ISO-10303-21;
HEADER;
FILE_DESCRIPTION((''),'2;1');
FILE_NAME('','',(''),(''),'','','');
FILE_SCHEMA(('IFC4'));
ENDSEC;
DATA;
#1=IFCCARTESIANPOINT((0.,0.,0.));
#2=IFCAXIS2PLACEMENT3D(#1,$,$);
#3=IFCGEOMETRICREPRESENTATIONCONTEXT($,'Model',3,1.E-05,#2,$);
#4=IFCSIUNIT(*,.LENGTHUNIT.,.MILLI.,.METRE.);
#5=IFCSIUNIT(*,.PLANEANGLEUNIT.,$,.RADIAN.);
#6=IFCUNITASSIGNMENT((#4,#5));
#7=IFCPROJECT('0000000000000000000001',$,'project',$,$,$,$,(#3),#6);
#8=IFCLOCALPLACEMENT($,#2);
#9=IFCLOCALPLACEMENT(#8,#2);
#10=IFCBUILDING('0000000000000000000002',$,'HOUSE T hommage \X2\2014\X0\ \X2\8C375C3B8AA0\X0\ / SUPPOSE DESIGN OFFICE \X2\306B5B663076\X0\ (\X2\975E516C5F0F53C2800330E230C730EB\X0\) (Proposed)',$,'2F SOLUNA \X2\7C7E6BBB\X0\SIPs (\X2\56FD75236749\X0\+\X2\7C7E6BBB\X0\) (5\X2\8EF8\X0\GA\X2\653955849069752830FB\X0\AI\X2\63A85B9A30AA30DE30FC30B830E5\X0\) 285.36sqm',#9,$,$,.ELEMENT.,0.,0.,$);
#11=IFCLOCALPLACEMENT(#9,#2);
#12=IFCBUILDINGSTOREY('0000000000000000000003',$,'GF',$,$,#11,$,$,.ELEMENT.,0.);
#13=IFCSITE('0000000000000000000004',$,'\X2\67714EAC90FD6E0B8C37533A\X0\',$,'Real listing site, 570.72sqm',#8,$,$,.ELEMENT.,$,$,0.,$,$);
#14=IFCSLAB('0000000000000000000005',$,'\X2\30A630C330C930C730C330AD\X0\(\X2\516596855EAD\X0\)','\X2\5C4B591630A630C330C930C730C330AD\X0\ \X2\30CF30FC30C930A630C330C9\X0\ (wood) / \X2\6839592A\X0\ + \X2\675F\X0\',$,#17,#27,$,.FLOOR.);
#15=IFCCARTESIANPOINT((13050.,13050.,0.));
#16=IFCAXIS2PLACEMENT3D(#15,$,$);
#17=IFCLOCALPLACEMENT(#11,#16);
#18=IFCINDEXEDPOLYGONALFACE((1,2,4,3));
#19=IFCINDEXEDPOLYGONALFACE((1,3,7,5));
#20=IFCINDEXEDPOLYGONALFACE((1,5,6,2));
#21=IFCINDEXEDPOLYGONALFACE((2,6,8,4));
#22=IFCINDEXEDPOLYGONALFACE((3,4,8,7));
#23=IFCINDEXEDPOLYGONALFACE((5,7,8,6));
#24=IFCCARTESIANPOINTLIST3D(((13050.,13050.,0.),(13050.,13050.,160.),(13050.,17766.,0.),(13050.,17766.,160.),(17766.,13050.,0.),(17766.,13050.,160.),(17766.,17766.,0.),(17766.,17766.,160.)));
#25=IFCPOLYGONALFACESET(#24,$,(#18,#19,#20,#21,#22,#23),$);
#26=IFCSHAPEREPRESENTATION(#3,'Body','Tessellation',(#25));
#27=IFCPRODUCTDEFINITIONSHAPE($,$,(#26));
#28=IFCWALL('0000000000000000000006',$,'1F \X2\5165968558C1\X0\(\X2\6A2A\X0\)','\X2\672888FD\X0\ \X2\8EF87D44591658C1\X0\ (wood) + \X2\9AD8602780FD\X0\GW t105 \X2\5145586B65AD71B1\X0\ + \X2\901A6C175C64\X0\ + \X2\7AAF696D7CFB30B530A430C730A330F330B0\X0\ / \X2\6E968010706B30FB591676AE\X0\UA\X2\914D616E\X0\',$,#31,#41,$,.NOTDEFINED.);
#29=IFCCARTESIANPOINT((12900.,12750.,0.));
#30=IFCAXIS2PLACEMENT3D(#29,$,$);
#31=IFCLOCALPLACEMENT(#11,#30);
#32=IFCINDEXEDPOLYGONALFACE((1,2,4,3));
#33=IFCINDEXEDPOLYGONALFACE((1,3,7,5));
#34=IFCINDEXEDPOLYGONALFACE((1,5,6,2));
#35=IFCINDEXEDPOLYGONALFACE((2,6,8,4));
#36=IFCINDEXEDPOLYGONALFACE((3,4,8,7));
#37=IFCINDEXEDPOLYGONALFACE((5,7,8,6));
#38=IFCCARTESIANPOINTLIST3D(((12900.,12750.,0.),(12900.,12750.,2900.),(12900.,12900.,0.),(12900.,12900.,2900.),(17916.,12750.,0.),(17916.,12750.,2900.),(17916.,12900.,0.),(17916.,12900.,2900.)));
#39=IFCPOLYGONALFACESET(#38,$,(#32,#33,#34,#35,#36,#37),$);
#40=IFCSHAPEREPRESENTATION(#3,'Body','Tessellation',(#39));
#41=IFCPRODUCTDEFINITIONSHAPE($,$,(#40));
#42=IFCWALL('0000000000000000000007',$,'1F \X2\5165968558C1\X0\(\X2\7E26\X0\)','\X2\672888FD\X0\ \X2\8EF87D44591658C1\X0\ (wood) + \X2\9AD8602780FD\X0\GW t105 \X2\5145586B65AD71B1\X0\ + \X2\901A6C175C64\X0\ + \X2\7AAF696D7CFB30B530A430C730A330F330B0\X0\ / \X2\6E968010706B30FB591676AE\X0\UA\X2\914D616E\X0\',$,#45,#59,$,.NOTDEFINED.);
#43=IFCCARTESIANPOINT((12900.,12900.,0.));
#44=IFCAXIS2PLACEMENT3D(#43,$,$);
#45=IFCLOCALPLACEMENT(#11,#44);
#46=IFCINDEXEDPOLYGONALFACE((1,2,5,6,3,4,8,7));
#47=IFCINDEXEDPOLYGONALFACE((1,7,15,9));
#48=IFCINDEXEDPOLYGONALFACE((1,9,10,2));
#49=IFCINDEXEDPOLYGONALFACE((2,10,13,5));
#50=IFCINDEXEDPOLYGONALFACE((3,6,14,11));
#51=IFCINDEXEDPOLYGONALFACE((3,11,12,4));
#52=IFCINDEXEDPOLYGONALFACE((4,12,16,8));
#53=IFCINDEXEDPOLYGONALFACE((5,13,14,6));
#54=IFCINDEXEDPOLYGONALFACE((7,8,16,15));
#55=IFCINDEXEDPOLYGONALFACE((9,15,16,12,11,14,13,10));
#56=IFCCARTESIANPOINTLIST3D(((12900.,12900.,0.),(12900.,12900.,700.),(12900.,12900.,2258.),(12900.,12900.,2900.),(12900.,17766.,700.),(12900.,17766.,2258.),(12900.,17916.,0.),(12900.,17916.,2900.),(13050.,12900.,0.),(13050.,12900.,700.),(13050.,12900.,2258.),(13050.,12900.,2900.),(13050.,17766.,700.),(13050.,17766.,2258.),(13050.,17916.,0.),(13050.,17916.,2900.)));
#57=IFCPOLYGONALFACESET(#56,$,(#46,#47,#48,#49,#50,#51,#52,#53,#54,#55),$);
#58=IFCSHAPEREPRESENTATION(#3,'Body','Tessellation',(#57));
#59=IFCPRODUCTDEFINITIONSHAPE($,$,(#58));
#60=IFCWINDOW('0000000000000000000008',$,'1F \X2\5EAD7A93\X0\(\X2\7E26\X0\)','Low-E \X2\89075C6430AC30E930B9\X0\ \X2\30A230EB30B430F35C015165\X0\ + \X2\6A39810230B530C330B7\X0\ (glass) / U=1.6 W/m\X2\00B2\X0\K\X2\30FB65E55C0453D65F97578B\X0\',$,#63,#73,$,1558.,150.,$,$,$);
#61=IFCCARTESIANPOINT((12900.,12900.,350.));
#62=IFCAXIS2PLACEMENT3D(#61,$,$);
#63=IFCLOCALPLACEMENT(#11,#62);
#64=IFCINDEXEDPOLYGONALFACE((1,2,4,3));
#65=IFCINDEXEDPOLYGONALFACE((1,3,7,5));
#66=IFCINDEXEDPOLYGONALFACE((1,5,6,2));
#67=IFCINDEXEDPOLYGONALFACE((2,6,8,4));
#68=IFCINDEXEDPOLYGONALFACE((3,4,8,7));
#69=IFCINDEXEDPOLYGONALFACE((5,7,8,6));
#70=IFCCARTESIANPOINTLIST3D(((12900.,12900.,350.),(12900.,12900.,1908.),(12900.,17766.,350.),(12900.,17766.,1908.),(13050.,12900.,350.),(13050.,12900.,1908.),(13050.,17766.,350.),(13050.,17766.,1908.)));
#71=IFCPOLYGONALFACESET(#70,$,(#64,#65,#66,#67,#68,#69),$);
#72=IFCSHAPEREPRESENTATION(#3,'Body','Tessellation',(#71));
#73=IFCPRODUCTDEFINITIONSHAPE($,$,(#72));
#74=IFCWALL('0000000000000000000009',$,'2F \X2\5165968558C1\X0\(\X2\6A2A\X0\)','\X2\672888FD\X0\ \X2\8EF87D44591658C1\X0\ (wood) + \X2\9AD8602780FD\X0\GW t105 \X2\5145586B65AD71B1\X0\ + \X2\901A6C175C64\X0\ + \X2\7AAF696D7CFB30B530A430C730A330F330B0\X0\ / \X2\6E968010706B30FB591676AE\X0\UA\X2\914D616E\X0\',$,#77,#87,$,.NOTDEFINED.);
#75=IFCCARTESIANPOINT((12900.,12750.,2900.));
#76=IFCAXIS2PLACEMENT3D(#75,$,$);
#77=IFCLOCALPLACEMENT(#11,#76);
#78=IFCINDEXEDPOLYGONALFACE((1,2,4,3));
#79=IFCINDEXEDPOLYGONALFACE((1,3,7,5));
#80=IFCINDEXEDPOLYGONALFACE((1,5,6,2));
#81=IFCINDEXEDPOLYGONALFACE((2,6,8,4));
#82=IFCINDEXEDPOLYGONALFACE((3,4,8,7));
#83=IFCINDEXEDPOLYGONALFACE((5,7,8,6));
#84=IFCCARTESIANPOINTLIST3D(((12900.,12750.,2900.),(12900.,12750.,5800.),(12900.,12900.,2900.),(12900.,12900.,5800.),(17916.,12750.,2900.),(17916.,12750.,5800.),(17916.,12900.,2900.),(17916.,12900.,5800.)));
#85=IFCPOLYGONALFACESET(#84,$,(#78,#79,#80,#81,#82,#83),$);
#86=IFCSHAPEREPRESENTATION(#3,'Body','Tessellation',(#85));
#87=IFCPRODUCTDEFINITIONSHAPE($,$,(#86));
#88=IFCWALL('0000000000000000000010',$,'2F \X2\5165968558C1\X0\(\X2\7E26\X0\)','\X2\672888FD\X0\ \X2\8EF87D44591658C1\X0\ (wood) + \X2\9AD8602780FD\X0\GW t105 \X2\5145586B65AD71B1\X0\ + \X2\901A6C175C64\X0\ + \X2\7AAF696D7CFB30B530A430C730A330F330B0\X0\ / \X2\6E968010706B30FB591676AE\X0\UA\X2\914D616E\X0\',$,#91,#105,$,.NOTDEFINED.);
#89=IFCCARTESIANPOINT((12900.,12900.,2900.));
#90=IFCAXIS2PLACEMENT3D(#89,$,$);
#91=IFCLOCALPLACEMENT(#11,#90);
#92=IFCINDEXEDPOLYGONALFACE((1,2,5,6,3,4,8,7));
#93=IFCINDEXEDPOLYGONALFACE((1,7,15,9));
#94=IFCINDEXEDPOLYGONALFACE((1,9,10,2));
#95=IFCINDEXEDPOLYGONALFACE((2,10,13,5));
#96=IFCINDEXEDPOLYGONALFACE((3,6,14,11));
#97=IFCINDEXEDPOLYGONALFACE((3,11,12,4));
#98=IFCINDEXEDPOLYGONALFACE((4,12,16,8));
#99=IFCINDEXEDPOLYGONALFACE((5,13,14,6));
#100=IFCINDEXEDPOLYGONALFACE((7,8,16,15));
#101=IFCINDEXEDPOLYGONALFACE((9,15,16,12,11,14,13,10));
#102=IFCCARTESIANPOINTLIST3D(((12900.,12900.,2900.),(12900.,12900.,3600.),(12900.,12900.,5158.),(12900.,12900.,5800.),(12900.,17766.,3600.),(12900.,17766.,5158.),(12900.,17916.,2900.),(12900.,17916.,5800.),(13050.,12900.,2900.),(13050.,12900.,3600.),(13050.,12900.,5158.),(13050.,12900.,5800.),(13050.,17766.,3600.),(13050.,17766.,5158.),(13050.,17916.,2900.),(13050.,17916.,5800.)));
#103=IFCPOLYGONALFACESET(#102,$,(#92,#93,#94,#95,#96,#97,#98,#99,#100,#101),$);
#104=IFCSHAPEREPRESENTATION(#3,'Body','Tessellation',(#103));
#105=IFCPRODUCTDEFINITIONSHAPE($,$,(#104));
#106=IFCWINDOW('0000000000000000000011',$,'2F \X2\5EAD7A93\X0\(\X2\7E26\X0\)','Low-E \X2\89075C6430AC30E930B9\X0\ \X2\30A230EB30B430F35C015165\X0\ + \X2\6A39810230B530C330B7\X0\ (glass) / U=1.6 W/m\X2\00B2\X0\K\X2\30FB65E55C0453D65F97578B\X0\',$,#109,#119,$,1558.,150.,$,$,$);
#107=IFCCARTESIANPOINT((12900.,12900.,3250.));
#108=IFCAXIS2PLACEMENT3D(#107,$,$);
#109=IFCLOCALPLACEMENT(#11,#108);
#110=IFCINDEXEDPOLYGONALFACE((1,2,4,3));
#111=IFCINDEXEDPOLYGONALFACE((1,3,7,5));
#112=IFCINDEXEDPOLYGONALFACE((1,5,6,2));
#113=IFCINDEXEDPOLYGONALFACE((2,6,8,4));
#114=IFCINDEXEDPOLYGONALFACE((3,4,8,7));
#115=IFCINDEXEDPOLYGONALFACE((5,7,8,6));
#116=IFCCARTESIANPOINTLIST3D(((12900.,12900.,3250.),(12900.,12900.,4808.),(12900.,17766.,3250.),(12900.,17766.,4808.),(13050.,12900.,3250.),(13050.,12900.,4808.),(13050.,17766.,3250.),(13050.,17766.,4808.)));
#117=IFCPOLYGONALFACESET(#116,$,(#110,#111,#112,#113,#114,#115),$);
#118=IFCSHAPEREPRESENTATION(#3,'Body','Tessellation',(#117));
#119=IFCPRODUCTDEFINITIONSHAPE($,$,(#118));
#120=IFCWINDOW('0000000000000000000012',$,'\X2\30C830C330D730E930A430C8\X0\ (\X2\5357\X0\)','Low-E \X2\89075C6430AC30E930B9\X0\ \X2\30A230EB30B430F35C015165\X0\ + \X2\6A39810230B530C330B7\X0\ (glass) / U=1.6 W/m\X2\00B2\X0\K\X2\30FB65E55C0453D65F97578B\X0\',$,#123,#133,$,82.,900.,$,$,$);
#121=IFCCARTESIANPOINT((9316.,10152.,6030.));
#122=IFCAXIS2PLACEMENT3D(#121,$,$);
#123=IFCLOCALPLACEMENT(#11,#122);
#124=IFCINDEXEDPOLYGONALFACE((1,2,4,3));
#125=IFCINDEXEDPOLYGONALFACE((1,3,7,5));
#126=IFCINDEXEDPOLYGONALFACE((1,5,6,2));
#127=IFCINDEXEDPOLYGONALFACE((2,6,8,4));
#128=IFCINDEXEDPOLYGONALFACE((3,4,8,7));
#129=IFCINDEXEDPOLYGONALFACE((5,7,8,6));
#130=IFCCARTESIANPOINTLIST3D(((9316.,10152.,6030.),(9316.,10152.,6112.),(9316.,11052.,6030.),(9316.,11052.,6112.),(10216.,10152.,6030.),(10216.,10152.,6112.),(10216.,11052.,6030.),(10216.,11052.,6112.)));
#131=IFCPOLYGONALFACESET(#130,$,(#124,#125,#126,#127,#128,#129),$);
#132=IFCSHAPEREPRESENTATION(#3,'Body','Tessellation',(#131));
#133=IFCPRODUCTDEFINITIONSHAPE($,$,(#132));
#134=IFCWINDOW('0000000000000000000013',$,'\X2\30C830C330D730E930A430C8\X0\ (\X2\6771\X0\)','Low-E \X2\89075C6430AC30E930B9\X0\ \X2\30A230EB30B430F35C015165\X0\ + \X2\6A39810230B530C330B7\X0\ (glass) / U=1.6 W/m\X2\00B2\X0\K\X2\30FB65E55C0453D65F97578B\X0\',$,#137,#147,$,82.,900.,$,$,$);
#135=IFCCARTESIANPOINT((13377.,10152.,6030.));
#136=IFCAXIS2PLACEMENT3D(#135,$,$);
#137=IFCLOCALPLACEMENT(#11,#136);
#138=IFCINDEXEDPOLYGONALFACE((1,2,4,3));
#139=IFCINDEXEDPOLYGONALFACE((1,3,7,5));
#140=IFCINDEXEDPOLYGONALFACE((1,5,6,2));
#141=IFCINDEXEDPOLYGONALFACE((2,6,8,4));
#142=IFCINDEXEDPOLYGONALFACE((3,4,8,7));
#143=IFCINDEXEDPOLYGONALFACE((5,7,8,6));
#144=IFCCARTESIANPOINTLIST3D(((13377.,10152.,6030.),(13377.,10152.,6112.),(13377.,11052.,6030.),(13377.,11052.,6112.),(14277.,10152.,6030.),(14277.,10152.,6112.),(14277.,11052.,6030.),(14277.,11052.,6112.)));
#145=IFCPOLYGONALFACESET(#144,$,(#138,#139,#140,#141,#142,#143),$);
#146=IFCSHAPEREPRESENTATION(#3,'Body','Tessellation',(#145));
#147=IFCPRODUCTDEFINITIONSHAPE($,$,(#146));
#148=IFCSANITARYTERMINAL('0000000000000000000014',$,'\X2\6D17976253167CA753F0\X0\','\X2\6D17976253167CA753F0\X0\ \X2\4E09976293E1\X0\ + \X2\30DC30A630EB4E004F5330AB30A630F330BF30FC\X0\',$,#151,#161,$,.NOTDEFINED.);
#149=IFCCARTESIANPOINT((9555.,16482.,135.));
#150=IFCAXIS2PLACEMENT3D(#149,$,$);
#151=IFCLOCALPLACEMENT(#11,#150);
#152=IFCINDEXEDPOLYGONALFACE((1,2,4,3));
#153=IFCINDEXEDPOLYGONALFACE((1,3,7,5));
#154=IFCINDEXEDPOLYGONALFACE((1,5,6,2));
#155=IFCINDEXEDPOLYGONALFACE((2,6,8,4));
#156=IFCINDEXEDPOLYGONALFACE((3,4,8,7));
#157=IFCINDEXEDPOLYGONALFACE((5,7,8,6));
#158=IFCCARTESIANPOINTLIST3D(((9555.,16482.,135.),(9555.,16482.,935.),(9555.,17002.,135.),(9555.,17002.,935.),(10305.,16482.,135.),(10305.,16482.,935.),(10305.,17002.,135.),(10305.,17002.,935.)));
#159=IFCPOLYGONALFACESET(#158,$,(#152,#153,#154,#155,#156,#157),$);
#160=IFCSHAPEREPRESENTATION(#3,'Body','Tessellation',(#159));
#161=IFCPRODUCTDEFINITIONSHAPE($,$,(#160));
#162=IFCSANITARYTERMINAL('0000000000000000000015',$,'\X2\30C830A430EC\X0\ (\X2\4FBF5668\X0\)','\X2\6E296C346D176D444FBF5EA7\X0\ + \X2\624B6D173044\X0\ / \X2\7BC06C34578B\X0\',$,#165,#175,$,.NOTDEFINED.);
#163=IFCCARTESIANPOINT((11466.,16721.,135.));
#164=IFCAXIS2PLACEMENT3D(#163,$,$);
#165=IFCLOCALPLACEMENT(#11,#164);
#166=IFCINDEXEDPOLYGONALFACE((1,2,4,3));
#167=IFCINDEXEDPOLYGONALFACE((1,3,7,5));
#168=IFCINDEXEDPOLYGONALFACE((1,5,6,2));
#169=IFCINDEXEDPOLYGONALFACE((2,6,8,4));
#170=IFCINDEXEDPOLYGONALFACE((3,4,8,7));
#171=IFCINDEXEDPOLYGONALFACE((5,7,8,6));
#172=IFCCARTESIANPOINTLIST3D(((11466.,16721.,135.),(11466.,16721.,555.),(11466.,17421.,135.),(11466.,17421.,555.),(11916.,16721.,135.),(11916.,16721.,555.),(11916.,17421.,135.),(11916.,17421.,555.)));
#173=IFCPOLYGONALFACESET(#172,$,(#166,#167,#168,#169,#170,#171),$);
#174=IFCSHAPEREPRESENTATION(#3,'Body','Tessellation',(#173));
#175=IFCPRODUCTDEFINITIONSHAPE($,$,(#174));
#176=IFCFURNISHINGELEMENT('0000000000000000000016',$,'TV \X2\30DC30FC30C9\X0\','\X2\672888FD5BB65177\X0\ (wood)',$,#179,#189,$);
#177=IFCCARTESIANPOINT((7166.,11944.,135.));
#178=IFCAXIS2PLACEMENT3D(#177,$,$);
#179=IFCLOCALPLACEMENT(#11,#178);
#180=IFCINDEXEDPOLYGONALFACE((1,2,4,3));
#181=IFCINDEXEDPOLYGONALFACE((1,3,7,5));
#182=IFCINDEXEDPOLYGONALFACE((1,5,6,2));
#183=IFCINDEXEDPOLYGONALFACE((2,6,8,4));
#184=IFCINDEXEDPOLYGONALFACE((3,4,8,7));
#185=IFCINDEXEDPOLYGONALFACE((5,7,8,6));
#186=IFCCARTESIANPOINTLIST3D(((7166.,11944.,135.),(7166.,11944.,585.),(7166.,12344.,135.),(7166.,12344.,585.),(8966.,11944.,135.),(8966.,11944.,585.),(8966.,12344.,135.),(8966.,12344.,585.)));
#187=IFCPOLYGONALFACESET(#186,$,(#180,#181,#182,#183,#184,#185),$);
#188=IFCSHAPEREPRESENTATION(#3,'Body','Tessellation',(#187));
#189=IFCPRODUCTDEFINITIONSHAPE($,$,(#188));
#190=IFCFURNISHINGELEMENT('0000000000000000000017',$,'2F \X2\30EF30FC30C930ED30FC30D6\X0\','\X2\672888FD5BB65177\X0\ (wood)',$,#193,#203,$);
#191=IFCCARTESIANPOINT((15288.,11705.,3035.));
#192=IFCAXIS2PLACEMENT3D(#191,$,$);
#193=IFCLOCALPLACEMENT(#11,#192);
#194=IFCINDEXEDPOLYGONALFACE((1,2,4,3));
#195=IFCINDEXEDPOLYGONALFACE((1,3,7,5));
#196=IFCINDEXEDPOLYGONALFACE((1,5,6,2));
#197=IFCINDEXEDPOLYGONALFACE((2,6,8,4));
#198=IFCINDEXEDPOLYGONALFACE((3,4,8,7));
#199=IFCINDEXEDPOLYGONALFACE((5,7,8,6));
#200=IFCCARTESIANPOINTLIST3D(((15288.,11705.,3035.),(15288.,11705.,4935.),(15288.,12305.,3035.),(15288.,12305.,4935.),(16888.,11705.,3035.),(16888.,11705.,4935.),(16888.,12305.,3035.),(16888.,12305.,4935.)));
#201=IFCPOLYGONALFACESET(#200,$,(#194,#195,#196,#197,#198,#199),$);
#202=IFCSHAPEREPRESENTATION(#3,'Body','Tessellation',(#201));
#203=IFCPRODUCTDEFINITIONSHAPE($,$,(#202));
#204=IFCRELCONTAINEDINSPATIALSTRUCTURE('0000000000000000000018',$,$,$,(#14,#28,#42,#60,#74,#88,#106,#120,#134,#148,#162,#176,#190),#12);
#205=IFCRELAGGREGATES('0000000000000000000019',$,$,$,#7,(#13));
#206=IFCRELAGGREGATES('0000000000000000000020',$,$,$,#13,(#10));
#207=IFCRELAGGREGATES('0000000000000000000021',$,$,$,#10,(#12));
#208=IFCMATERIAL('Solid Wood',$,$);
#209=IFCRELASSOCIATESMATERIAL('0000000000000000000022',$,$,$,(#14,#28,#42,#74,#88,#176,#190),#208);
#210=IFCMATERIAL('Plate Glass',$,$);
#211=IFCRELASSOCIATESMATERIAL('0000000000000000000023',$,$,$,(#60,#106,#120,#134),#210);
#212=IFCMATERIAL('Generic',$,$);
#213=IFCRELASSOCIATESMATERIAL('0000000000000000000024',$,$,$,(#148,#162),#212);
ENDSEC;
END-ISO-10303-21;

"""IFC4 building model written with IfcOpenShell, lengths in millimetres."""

from ifc_helpers import new_model, si_unit, frame, frame_2d, origin, place, context, project, spatial, rectangle, extrude, material, element, fill, save


model = new_model("IFC4")

# Units and contexts
model_context = context("Model", 3, precision=1e-05, world=origin())
ifc_project = project(units=[si_unit("LENGTHUNIT", "METRE", prefix="MILLI"), si_unit("PLANEANGLEUNIT", "RADIAN")], contexts=[model_context])

# Site, building, storey
site_placement = place(None, origin())
site = spatial("IfcSite", under=ifc_project, at=site_placement, Name="東京都渋谷区", ObjectType="Real listing site, 570.72sqm", CompositionType="ELEMENT", RefElevation=0.0)
building_placement = place(site_placement, origin())
building = spatial("IfcBuilding", under=site, at=building_placement, Name="HOUSE T hommage — 谷尻誠 / SUPPOSE DESIGN OFFICE に学ぶ (非公式参考モデル) (Proposed)", ObjectType="2F SOLUNA 籾殻SIPs (国産杉+籾殻) (5軸GA改善適用・AI推定オマージュ) 285.36sqm", CompositionType="ELEMENT", ElevationOfRefHeight=0.0, ElevationOfTerrain=0.0)
storey_placement = place(building_placement, origin())
storey = spatial("IfcBuildingStorey", under=building, at=storey_placement, Name="GF", CompositionType="ELEMENT", Elevation=0.0)

# Slab
ifc_material_1 = material(Name="Solid Wood")
slab_placement = place(storey_placement, frame((13050.0, 13050.0, 0.0)))
element("IfcSlab", 1, at=slab_placement, inside=storey, material=ifc_material_1, Name="ウッドデッキ(入隅庭)", Description="屋外ウッドデッキ ハードウッド (wood) / 根太 + 束", PredefinedType="FLOOR", context=model_context, shape_type="SweptSolid", body=[
    extrude(rectangle(XDim=4716.0, YDim=4716.0, at=frame_2d((2358.0, 2358.0))), frame((13050.0, 13050.0, 0.0)), (0.0, 0.0, 1.0), 160.0),
])

# Wall
wall_1_placement = place(storey_placement, frame((12900.0, 12750.0, 0.0)))
element("IfcWall", 2, at=wall_1_placement, inside=storey, material=ifc_material_1, Name="1F 入隅壁(横)", Description="木製 軸組外壁 (wood) + 高性能GW t105 充填断熱 + 通気層 + 窯業系サイディング / 準耐火・外皮UA配慮", PredefinedType="NOTDEFINED", context=model_context, shape_type="SweptSolid", body=[
    extrude(rectangle(XDim=5016.0, YDim=150.0, at=frame_2d((2508.0, 75.0))), frame((12900.0, 12750.0, 0.0)), (0.0, 0.0, 1.0), 2900.0),
])

# Wall, opening, window
wall_2_placement = place(storey_placement, frame((12900.0, 12900.0, 0.0)))
wall_2 = element("IfcWall", 3, at=wall_2_placement, inside=storey, material=ifc_material_1, Name="1F 入隅壁(縦)", Description="木製 軸組外壁 (wood) + 高性能GW t105 充填断熱 + 通気層 + 窯業系サイディング / 準耐火・外皮UA配慮", PredefinedType="NOTDEFINED", context=model_context, shape_type="SweptSolid", body=[
    extrude(rectangle(XDim=150.0, YDim=5016.0, at=frame_2d((75.0, 2508.0))), frame((12900.0, 12900.0, 0.0)), (0.0, 0.0, 1.0), 2900.0),
])
opening_1_placement = place(storey_placement, frame((12900.0, 12900.0, 350.0)))
opening_1 = element("IfcOpeningElement", 4, at=opening_1_placement, cuts=wall_2, PredefinedType="NOTDEFINED", context=model_context, shape_type="SweptSolid", body=[
    extrude(rectangle(XDim=150.0, YDim=4866.0, at=frame_2d((75.0, 2433.0))), frame((12900.0, 12900.0, 350.0)), (0.0, 0.0, 1.0), 1558.0),
])
ifc_material_2 = material(Name="Plate Glass")
window_1_placement = place(storey_placement, frame((12900.0, 12900.0, 350.0)))
window_1 = element("IfcWindow", 5, at=window_1_placement, inside=storey, material=ifc_material_2, Name="1F 庭窓(縦)", Description="Low-E 複層ガラス アルゴン封入 + 樹脂サッシ (glass) / U=1.6 W/m²K・日射取得型", OverallHeight=1558.0, OverallWidth=150.0, context=model_context, shape_type="SweptSolid", body=[
    extrude(rectangle(XDim=150.0, YDim=4866.0, at=frame_2d((75.0, 2433.0))), frame((12900.0, 12900.0, 350.0)), (0.0, 0.0, 1.0), 1558.0),
])
fill(opening_1, window_1)

# Wall
wall_3_placement = place(storey_placement, frame((12900.0, 12750.0, 2900.0)))
element("IfcWall", 6, at=wall_3_placement, inside=storey, material=ifc_material_1, Name="2F 入隅壁(横)", Description="木製 軸組外壁 (wood) + 高性能GW t105 充填断熱 + 通気層 + 窯業系サイディング / 準耐火・外皮UA配慮", PredefinedType="NOTDEFINED", context=model_context, shape_type="SweptSolid", body=[
    extrude(rectangle(XDim=5016.0, YDim=150.0, at=frame_2d((2508.0, 75.0))), frame((12900.0, 12750.0, 2900.0)), (0.0, 0.0, 1.0), 2900.0),
])

# Wall, opening, window
wall_4_placement = place(storey_placement, frame((12900.0, 12900.0, 2900.0)))
wall_4 = element("IfcWall", 7, at=wall_4_placement, inside=storey, material=ifc_material_1, Name="2F 入隅壁(縦)", Description="木製 軸組外壁 (wood) + 高性能GW t105 充填断熱 + 通気層 + 窯業系サイディング / 準耐火・外皮UA配慮", PredefinedType="NOTDEFINED", context=model_context, shape_type="SweptSolid", body=[
    extrude(rectangle(XDim=150.0, YDim=5016.0, at=frame_2d((75.0, 2508.0))), frame((12900.0, 12900.0, 2900.0)), (0.0, 0.0, 1.0), 2900.0),
])
opening_2_placement = place(storey_placement, frame((12900.0, 12900.0, 3250.0)))
opening_2 = element("IfcOpeningElement", 8, at=opening_2_placement, cuts=wall_4, PredefinedType="NOTDEFINED", context=model_context, shape_type="SweptSolid", body=[
    extrude(rectangle(XDim=150.0, YDim=4866.0, at=frame_2d((75.0, 2433.0))), frame((12900.0, 12900.0, 3250.0)), (0.0, 0.0, 1.0), 1558.0),
])
window_2_placement = place(storey_placement, frame((12900.0, 12900.0, 3250.0)))
window_2 = element("IfcWindow", 9, at=window_2_placement, inside=storey, material=ifc_material_2, Name="2F 庭窓(縦)", Description="Low-E 複層ガラス アルゴン封入 + 樹脂サッシ (glass) / U=1.6 W/m²K・日射取得型", OverallHeight=1558.0, OverallWidth=150.0, context=model_context, shape_type="SweptSolid", body=[
    extrude(rectangle(XDim=150.0, YDim=4866.0, at=frame_2d((75.0, 2433.0))), frame((12900.0, 12900.0, 3250.0)), (0.0, 0.0, 1.0), 1558.0),
])
fill(opening_2, window_2)

# Windows
window_3_placement = place(storey_placement, frame((9316.0, 10152.0, 6030.0)))
element("IfcWindow", 10, at=window_3_placement, inside=storey, material=ifc_material_2, Name="トップライト (南)", Description="Low-E 複層ガラス アルゴン封入 + 樹脂サッシ (glass) / U=1.6 W/m²K・日射取得型", OverallHeight=82.0, OverallWidth=900.0, context=model_context, shape_type="SweptSolid", body=[
    extrude(rectangle(XDim=900.0, YDim=900.0, at=frame_2d((450.0, 450.0))), frame((9316.0, 10152.0, 6030.0)), (0.0, 0.0, 1.0), 82.0),
])
window_4_placement = place(storey_placement, frame((13377.0, 10152.0, 6030.0)))
element("IfcWindow", 11, at=window_4_placement, inside=storey, material=ifc_material_2, Name="トップライト (東)", Description="Low-E 複層ガラス アルゴン封入 + 樹脂サッシ (glass) / U=1.6 W/m²K・日射取得型", OverallHeight=82.0, OverallWidth=900.0, context=model_context, shape_type="SweptSolid", body=[
    extrude(rectangle(XDim=900.0, YDim=900.0, at=frame_2d((450.0, 450.0))), frame((13377.0, 10152.0, 6030.0)), (0.0, 0.0, 1.0), 82.0),
])

# Sanitary terminals
ifc_material_3 = material(Name="Generic")
sanitary_terminal_1_placement = place(storey_placement, frame((9555.0, 16482.0, 135.0)))
element("IfcSanitaryTerminal", 12, at=sanitary_terminal_1_placement, inside=storey, material=ifc_material_3, Name="洗面化粧台", Description="洗面化粧台 三面鏡 + ボウル一体カウンター", PredefinedType="NOTDEFINED", context=model_context, shape_type="SweptSolid", body=[
    extrude(rectangle(XDim=750.0, YDim=520.0, at=frame_2d((375.0, 260.0))), frame((9555.0, 16482.0, 135.0)), (0.0, 0.0, 1.0), 800.0),
])
sanitary_terminal_2_placement = place(storey_placement, frame((11466.0, 16721.0, 135.0)))
element("IfcSanitaryTerminal", 13, at=sanitary_terminal_2_placement, inside=storey, material=ifc_material_3, Name="トイレ (便器)", Description="温水洗浄便座 + 手洗い / 節水型", PredefinedType="NOTDEFINED", context=model_context, shape_type="SweptSolid", body=[
    extrude(rectangle(XDim=450.0, YDim=700.0, at=frame_2d((225.0, 350.0))), frame((11466.0, 16721.0, 135.0)), (0.0, 0.0, 1.0), 420.0),
])

# Furnishing elements
furnishing_1_placement = place(storey_placement, frame((7166.0, 11944.0, 135.0)))
element("IfcFurnishingElement", 14, at=furnishing_1_placement, inside=storey, material=ifc_material_1, Name="TV ボード", Description="木製家具 (wood)", context=model_context, shape_type="SweptSolid", body=[
    extrude(rectangle(XDim=1800.0, YDim=400.0, at=frame_2d((900.0, 200.0))), frame((7166.0, 11944.0, 135.0)), (0.0, 0.0, 1.0), 450.0),
])
furnishing_2_placement = place(storey_placement, frame((15288.0, 11705.0, 3035.0)))
element("IfcFurnishingElement", 15, at=furnishing_2_placement, inside=storey, material=ifc_material_1, Name="2F ワードローブ", Description="木製家具 (wood)", context=model_context, shape_type="SweptSolid", body=[
    extrude(rectangle(XDim=1600.0, YDim=600.0, at=frame_2d((800.0, 300.0))), frame((15288.0, 11705.0, 3035.0)), (0.0, 0.0, 1.0), 1900.0),
])

save(model, "model.ifc")
